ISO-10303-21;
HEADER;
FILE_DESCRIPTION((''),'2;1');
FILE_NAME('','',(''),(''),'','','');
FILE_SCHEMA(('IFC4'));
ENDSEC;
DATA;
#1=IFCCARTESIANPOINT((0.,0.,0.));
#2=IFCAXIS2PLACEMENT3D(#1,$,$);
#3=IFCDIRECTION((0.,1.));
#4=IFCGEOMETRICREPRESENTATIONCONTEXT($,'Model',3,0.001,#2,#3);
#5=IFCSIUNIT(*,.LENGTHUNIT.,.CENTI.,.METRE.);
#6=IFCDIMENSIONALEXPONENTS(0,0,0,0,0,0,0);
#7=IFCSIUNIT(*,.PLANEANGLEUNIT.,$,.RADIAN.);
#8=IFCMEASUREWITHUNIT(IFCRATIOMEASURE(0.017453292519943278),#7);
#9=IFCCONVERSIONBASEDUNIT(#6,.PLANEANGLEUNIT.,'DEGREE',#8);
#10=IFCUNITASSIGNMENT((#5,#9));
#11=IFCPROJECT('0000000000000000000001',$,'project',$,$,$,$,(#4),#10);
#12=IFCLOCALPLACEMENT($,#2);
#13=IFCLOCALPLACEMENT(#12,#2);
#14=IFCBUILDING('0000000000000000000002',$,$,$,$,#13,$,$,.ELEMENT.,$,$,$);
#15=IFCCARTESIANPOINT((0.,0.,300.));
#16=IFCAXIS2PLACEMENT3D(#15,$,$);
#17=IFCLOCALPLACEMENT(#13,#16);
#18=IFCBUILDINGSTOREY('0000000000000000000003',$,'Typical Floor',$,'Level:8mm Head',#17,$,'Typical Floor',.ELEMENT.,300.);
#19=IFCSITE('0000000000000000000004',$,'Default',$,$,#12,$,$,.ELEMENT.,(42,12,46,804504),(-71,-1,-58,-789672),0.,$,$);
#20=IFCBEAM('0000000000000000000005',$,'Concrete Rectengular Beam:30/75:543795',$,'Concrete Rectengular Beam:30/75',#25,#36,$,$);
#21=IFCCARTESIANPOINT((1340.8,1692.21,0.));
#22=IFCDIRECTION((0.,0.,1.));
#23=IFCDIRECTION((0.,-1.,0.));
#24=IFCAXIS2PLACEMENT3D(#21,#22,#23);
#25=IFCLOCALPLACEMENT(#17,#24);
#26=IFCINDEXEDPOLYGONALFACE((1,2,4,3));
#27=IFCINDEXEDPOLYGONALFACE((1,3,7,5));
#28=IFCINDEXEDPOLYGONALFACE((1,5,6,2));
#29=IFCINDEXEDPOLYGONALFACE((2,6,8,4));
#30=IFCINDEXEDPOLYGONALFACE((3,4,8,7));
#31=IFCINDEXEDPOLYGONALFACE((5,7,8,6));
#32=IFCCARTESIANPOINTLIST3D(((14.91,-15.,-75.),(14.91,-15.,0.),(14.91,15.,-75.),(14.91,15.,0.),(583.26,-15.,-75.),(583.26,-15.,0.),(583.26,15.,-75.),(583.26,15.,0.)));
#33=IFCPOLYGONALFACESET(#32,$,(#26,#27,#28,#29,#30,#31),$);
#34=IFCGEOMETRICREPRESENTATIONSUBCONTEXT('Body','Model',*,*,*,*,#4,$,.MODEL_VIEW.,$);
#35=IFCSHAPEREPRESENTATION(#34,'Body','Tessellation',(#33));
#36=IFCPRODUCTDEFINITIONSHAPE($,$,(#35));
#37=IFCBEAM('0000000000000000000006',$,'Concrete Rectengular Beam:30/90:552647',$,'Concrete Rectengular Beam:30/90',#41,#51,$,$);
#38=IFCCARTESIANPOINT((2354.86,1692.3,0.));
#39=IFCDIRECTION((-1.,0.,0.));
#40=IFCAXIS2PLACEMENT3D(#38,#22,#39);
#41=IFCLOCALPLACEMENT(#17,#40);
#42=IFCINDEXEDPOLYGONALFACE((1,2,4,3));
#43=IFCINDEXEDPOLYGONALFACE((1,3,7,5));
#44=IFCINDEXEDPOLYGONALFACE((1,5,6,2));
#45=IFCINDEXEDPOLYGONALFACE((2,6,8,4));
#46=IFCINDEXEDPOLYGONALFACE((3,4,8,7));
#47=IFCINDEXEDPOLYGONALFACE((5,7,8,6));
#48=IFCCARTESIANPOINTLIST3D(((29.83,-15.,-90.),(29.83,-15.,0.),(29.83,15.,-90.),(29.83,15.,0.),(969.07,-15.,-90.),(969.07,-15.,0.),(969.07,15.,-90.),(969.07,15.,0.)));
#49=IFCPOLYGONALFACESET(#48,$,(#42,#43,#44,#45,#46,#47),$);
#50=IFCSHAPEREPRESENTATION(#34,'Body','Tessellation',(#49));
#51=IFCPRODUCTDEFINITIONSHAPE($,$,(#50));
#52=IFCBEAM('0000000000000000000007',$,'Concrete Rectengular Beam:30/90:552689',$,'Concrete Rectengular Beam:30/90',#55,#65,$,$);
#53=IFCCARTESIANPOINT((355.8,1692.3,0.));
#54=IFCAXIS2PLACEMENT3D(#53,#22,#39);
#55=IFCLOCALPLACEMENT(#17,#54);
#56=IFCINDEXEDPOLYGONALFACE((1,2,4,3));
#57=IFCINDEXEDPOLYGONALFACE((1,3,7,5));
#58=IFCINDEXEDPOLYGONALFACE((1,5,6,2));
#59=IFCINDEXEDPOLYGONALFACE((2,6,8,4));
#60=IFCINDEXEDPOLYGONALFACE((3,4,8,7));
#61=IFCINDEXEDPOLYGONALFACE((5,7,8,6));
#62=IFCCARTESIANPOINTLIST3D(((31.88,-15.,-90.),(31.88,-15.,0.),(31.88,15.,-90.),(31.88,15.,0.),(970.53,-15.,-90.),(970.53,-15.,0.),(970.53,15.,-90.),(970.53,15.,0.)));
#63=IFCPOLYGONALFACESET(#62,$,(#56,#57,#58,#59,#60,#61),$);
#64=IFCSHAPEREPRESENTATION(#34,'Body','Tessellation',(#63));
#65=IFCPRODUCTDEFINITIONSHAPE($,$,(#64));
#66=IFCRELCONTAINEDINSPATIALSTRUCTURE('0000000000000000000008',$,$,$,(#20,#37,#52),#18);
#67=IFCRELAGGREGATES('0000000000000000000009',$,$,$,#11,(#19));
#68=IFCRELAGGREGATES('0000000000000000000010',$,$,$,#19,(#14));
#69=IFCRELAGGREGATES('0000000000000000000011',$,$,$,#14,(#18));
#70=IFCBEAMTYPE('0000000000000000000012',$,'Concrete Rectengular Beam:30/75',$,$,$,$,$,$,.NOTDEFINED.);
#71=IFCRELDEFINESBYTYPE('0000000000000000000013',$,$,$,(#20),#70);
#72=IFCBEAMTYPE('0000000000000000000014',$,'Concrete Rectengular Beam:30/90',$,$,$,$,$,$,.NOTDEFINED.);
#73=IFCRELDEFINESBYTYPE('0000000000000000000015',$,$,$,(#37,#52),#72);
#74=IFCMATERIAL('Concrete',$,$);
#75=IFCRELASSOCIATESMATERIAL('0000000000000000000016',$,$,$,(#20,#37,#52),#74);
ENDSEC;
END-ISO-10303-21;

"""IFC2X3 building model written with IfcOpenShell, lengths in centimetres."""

from ifc_helpers import new_model, entity, si_unit, converted_unit, direction, frame, frame_2d, origin, place, context, subcontext, project, spatial, rectangle, extrude, material, type_object, element, save


model = new_model("IFC2X3")

# Units and contexts
model_context = context("Model", 3, precision=0.001, world=origin(), true_north=direction((0.0, 1.0)))
body_context = subcontext(model_context, "Body", "Model", "MODEL_VIEW")
ifc_project = project(units=[si_unit("LENGTHUNIT", "METRE", prefix="CENTI"), converted_unit("PLANEANGLEUNIT", "DEGREE", entity("IfcRatioMeasure", 0.017453292519943278), si_unit("PLANEANGLEUNIT", "RADIAN"), dimensions=[0, 0, 0, 0, 0, 0, 0])], contexts=[model_context])

# Site, building, storey
site_placement = place(None, origin())
site = spatial("IfcSite", under=ifc_project, at=site_placement, Name="Default", CompositionType="ELEMENT", RefLatitude=(42, 12, 46, 804504), RefLongitude=(-71, -1, -58, -789672), RefElevation=0.0)
building_placement = place(site_placement, origin())
building = spatial("IfcBuilding", under=site, at=building_placement, CompositionType="ELEMENT")
storey_placement = place(building_placement, frame((0.0, 0.0, 300.0)))
storey = spatial("IfcBuildingStorey", under=building, at=storey_placement, Name="Typical Floor", ObjectType="Level:8mm Head", LongName="Typical Floor", CompositionType="ELEMENT", Elevation=300.0)

# Beams
ifc_material = material(Name="Concrete")
beam_type_1 = type_object("IfcBeamType", Name="Concrete Rectengular Beam:30/75", PredefinedType="NOTDEFINED")
beam_1_placement = place(storey_placement, frame((1340.8, 1692.21, 0.0), z_axis=(0.0, 0.0, 1.0), x_axis=(0.0, -1.0, 0.0)))
element("IfcBeam", 1, at=beam_1_placement, inside=storey, type_object=beam_type_1, material=ifc_material, Name="Concrete Rectengular Beam:30/75:543795", ObjectType="Concrete Rectengular Beam:30/75", context=body_context, shape_type="SweptSolid", body=[
    extrude(rectangle(XDim=75.0, YDim=30.0, at=frame_2d((0.0, 0.0), x_axis=(1.0, 0.0))), frame((14.91, 0.0, -37.5), z_axis=(1.0, 0.0, 0.0), x_axis=(0.0, 0.0, -1.0)), (0.0, 0.0, 1.0), 568.35),
])
beam_type_2 = type_object("IfcBeamType", Name="Concrete Rectengular Beam:30/90", PredefinedType="NOTDEFINED")
beam_2_placement = place(storey_placement, frame((2354.86, 1692.3, 0.0), z_axis=(0.0, 0.0, 1.0), x_axis=(-1.0, 0.0, 0.0)))
element("IfcBeam", 2, at=beam_2_placement, inside=storey, type_object=beam_type_2, material=ifc_material, Name="Concrete Rectengular Beam:30/90:552647", ObjectType="Concrete Rectengular Beam:30/90", context=body_context, shape_type="SweptSolid", body=[
    extrude(rectangle(XDim=90.0, YDim=30.0, at=frame_2d((0.0, 0.0), x_axis=(1.0, 0.0))), frame((29.83, 0.0, -45.0), z_axis=(1.0, 0.0, 0.0), x_axis=(0.0, 0.0, -1.0)), (0.0, 0.0, 1.0), 939.24),
])
beam_3_placement = place(storey_placement, frame((355.8, 1692.3, 0.0), z_axis=(0.0, 0.0, 1.0), x_axis=(-1.0, 0.0, 0.0)))
element("IfcBeam", 3, at=beam_3_placement, inside=storey, type_object=beam_type_2, material=ifc_material, Name="Concrete Rectengular Beam:30/90:552689", ObjectType="Concrete Rectengular Beam:30/90", context=body_context, shape_type="SweptSolid", body=[
    extrude(rectangle(XDim=90.0, YDim=30.0, at=frame_2d((0.0, 0.0), x_axis=(1.0, 0.0))), frame((31.88, 0.0, -45.0), z_axis=(1.0, 0.0, 0.0), x_axis=(0.0, 0.0, -1.0)), (0.0, 0.0, 1.0), 938.65),
])

save(model, "model.ifc")
